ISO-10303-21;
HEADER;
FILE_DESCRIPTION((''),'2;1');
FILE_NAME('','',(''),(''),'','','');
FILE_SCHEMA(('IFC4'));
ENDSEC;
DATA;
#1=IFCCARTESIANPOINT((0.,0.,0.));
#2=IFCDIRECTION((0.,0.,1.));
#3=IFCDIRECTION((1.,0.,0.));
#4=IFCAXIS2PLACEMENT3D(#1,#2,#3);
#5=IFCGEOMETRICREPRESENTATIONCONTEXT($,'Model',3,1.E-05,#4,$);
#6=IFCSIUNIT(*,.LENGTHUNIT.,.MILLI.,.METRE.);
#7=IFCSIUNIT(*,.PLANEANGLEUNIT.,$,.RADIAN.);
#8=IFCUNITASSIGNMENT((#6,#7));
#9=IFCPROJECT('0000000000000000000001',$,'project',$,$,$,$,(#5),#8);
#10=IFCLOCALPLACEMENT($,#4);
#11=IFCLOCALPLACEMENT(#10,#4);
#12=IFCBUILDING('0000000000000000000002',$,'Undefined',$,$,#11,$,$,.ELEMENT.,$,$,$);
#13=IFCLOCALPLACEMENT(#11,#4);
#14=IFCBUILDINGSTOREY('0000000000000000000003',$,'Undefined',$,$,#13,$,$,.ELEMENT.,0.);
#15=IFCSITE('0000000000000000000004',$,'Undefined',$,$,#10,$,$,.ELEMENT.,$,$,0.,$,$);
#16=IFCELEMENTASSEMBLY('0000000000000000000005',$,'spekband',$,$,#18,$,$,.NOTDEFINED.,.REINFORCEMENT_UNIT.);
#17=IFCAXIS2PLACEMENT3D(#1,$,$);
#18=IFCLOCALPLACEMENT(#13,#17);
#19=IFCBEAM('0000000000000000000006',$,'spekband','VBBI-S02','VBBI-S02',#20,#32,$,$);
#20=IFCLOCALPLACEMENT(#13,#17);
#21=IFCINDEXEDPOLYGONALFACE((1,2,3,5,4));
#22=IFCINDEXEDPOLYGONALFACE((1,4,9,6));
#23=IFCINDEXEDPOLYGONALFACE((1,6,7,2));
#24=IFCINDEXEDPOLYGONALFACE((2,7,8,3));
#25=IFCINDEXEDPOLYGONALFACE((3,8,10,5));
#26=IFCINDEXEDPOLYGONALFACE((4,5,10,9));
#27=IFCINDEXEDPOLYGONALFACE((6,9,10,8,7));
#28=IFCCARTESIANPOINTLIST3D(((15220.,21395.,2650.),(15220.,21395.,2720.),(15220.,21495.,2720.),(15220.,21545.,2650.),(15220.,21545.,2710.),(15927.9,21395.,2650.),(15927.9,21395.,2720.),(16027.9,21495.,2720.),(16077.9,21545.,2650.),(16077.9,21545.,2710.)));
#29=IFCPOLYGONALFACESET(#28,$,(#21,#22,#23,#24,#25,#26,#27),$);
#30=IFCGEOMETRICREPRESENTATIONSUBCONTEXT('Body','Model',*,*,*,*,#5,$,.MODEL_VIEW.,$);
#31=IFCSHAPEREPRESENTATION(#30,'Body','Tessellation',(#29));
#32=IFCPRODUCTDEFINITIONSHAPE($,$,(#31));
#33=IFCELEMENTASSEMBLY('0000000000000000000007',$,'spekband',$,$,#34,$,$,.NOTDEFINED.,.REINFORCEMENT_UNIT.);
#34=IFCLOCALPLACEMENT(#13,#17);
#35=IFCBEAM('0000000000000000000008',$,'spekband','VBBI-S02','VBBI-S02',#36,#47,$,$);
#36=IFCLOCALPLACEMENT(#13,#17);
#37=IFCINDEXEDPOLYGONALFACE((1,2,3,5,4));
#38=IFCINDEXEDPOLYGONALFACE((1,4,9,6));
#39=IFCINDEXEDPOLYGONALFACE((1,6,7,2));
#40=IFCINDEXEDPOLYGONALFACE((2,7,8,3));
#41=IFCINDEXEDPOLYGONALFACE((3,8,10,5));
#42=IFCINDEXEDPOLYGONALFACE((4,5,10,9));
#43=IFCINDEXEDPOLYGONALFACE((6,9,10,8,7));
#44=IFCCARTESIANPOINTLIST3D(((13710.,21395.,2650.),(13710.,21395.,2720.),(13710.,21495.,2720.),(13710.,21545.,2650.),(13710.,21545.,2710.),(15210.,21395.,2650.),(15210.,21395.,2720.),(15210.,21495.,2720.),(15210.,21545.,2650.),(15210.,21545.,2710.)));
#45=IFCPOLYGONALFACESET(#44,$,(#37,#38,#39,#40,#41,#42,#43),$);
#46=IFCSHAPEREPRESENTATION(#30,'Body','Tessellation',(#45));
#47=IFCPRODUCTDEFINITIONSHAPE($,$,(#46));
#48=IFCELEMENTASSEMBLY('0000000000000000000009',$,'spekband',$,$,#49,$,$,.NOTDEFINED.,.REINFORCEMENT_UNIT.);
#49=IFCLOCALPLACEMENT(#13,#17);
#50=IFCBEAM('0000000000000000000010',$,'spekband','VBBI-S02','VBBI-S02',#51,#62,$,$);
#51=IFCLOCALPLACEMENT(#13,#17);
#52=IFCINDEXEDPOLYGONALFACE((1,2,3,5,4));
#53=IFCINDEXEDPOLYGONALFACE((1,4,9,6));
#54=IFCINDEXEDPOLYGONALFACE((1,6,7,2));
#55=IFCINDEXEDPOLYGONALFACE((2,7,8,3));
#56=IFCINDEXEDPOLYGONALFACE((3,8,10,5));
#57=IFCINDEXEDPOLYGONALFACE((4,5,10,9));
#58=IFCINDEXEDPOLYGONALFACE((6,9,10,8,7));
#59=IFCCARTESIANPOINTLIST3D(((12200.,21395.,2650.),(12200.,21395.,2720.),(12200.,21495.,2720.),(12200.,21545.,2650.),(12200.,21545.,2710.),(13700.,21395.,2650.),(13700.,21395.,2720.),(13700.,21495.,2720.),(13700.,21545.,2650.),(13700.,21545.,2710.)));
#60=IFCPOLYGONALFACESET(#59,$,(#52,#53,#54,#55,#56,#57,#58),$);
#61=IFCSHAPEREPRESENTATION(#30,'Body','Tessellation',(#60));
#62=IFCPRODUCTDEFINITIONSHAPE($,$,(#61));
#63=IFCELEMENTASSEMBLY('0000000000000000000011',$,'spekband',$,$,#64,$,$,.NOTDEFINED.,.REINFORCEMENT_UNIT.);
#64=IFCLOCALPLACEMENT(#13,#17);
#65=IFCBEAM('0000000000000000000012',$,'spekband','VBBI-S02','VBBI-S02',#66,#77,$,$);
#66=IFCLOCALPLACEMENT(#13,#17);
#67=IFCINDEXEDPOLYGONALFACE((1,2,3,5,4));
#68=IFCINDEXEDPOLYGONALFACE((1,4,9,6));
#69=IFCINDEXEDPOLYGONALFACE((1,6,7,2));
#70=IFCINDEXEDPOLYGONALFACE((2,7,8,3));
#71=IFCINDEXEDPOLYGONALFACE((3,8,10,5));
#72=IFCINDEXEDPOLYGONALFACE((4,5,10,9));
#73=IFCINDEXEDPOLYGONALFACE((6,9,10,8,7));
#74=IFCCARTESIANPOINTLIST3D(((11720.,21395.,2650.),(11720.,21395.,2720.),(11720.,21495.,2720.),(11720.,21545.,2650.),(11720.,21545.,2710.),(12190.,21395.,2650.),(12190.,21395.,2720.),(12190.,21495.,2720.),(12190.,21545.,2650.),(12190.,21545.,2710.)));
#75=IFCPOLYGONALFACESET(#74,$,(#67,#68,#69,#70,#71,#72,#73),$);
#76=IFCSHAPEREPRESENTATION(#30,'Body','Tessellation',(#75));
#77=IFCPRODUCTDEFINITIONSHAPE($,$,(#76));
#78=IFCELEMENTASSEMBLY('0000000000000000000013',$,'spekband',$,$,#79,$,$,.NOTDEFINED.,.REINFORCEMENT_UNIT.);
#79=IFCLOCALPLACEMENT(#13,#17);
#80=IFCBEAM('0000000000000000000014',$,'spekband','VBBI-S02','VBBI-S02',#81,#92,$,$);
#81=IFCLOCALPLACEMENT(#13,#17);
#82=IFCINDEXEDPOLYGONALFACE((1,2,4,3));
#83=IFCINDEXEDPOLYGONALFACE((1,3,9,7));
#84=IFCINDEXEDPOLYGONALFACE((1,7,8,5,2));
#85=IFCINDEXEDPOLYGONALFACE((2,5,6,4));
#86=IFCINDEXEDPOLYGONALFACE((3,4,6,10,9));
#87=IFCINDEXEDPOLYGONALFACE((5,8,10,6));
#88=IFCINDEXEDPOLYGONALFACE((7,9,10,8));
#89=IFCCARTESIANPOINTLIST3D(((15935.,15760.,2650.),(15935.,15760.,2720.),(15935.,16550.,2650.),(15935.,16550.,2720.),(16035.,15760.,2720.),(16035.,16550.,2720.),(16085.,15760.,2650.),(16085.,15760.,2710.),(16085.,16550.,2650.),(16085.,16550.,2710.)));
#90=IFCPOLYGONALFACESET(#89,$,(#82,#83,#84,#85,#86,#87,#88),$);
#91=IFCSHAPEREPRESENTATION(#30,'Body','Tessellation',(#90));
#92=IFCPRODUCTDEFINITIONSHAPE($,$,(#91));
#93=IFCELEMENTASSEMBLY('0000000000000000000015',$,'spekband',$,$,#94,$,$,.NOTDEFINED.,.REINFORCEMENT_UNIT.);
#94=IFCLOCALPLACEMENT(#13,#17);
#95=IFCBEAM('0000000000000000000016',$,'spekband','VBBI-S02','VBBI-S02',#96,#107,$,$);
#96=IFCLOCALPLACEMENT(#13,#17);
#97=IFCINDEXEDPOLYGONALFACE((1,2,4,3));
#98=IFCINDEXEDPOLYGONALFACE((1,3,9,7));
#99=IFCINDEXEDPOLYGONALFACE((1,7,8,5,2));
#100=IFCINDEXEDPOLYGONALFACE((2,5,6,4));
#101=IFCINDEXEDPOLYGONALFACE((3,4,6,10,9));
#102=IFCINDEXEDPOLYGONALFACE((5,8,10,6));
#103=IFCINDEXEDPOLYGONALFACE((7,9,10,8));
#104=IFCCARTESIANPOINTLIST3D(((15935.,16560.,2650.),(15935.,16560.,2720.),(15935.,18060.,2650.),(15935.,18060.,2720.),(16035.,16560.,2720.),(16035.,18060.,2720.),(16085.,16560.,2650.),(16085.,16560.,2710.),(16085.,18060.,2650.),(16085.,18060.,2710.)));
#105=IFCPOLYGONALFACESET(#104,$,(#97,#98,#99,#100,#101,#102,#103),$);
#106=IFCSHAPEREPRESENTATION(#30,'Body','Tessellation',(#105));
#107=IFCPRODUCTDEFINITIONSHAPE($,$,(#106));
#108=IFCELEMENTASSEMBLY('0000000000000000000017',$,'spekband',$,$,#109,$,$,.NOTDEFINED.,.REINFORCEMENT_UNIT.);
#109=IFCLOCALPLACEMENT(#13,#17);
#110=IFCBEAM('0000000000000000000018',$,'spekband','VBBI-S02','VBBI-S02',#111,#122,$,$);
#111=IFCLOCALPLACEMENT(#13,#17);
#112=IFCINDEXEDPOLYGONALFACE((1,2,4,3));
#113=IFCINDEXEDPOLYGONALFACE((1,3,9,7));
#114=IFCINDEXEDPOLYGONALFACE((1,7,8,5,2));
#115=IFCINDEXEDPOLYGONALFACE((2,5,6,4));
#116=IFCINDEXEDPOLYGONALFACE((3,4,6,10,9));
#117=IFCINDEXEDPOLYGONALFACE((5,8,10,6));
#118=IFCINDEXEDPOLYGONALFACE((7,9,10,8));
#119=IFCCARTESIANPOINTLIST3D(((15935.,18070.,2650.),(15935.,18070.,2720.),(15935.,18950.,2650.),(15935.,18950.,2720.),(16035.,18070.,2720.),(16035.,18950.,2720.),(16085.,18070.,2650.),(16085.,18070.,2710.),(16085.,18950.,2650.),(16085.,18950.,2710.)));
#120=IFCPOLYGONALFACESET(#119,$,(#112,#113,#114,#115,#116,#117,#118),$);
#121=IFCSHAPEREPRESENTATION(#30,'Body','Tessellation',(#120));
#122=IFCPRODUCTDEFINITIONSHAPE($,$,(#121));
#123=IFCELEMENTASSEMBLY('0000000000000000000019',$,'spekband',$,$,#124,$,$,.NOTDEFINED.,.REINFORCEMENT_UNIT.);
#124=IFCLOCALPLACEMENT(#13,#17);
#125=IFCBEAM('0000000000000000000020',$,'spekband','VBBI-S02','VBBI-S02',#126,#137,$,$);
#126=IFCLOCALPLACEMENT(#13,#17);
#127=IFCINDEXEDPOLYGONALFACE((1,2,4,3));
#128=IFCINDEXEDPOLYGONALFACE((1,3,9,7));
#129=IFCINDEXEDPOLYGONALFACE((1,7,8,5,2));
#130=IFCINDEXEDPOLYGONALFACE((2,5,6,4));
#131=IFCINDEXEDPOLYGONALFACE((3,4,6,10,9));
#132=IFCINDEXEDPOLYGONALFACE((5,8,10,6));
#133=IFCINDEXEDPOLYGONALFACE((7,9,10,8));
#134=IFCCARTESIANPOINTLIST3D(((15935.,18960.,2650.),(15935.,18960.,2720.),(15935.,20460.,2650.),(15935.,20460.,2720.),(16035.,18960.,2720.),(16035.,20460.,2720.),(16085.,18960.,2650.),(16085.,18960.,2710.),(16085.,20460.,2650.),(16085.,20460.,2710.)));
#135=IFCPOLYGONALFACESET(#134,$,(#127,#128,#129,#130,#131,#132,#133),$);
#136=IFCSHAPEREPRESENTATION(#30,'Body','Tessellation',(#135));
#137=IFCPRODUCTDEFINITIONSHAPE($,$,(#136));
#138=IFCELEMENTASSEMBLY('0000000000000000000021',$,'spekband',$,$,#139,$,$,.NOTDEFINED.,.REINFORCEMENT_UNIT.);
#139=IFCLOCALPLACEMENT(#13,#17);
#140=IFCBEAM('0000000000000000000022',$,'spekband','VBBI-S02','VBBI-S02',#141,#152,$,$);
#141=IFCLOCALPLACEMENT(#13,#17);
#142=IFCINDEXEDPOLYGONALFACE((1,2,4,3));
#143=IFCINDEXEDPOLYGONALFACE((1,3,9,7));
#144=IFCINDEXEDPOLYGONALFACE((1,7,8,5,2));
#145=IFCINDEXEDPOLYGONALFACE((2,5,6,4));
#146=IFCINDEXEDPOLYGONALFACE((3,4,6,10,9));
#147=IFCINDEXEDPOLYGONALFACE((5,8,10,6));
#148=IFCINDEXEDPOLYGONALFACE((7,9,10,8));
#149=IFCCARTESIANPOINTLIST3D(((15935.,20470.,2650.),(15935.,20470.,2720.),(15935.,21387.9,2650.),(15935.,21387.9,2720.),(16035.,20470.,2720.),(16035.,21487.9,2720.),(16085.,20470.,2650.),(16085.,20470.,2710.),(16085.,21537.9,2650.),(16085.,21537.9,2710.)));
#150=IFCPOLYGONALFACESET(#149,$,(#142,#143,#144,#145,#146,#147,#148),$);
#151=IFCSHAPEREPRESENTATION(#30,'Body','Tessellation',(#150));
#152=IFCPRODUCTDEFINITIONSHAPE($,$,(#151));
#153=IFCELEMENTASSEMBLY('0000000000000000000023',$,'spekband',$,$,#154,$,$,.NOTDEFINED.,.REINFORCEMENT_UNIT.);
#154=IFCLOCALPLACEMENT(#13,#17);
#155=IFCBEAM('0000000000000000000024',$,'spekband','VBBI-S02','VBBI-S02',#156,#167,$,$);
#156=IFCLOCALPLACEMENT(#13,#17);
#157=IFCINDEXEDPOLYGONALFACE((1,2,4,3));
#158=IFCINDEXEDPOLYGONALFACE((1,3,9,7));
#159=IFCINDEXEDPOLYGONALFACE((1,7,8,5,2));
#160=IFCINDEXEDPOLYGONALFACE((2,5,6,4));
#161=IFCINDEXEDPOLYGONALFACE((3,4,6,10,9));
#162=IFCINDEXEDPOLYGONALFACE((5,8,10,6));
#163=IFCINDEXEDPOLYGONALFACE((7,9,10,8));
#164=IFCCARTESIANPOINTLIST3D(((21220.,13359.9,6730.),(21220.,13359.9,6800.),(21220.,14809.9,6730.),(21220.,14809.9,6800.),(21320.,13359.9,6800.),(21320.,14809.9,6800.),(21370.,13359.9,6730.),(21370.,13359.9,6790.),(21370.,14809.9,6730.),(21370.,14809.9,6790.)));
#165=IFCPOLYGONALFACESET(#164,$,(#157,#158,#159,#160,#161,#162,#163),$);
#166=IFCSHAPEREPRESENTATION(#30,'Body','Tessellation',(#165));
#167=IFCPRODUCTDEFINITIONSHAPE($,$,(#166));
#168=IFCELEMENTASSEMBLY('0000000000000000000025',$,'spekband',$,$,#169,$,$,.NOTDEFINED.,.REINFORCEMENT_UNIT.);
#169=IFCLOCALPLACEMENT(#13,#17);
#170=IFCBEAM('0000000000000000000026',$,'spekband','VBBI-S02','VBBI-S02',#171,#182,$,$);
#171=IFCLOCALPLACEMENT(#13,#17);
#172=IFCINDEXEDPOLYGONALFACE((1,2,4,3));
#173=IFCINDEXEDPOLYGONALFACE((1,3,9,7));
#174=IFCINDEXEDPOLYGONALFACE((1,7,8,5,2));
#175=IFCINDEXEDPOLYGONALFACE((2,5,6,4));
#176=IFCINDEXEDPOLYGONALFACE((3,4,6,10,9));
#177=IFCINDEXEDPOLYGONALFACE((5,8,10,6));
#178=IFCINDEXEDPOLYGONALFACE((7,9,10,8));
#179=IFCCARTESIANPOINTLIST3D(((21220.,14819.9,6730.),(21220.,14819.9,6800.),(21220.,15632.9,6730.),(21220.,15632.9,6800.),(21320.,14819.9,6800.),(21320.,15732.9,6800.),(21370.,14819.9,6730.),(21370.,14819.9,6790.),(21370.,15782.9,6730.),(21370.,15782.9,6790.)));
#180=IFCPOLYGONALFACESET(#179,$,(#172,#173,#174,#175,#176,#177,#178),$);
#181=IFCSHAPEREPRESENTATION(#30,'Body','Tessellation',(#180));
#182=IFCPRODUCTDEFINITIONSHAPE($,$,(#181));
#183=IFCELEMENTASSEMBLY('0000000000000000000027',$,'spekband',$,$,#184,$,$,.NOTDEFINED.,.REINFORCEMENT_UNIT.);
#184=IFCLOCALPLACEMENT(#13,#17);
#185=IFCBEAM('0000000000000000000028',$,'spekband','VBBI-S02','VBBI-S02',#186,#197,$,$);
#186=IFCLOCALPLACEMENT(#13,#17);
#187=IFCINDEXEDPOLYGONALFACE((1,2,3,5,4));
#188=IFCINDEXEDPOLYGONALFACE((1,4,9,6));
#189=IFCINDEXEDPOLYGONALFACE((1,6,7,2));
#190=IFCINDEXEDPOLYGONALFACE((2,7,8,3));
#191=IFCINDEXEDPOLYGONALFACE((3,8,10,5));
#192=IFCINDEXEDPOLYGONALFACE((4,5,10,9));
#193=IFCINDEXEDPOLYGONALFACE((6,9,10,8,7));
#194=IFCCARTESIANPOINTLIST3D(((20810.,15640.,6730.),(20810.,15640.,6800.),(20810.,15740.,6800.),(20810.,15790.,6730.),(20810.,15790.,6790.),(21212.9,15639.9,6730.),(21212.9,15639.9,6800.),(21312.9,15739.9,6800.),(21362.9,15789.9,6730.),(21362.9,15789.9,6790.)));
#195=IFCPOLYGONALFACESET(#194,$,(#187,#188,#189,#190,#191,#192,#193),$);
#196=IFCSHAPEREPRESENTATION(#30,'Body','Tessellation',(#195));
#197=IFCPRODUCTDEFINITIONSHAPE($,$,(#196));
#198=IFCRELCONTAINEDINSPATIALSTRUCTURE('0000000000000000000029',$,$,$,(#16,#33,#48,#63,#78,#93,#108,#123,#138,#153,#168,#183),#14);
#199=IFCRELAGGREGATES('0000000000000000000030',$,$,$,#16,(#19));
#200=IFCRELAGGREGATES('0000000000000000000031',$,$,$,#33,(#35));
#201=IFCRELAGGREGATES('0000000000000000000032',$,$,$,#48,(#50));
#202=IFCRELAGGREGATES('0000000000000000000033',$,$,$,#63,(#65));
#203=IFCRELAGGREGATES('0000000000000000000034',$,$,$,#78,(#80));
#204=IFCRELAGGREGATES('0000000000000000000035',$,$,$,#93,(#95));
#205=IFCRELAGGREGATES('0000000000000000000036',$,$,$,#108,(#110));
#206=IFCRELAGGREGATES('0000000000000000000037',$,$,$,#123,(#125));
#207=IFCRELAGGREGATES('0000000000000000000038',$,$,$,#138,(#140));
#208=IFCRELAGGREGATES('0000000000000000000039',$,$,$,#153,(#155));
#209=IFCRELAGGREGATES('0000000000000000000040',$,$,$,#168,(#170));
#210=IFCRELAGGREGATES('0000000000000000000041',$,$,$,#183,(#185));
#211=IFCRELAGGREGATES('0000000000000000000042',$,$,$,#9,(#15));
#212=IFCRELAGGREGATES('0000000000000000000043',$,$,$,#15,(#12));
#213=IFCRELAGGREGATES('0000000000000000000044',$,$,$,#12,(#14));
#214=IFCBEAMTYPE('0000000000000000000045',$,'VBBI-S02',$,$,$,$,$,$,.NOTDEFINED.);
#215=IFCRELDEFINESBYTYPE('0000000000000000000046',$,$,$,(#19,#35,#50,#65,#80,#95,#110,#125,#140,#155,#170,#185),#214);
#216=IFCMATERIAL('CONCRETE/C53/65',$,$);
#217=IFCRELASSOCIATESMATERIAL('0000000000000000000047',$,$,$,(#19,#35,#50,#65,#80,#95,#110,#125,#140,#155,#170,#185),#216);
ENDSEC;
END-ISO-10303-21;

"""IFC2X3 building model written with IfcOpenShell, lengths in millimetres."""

from ifc_helpers import new_model, si_unit, frame, origin_with_axes, place, context, subcontext, project, spatial, polyline, outline, extrude, clip, halfspace, material, type_object, element, aggregate, save


model = new_model("IFC2X3")

# Units and contexts
model_context = context("Model", 3, precision=1e-05, world=origin_with_axes())
body_context = subcontext(model_context, "Body", "Model", "MODEL_VIEW")
ifc_project = project(units=[si_unit("LENGTHUNIT", "METRE", prefix="MILLI"), si_unit("PLANEANGLEUNIT", "RADIAN")], contexts=[model_context])

# Site, building, storey
site_placement = place(None, origin_with_axes())
site = spatial("IfcSite", under=ifc_project, at=site_placement, Name="Undefined", CompositionType="ELEMENT", RefElevation=0.0)
building_placement = place(site_placement, origin_with_axes())
building = spatial("IfcBuilding", under=site, at=building_placement, Name="Undefined", CompositionType="ELEMENT")
storey_placement = place(building_placement, origin_with_axes())
storey = spatial("IfcBuildingStorey", under=building, at=storey_placement, Name="Undefined", CompositionType="ELEMENT", Elevation=0.0)

# Element assemblies, beams
assembly_1_placement = place(storey_placement, origin_with_axes())
assembly_1 = element("IfcElementAssembly", 1, at=assembly_1_placement, inside=storey, Name="spekband", AssemblyPlace="NOTDEFINED", PredefinedType="REINFORCEMENT_UNIT")
ifc_material = material(Name="CONCRETE/C53/65")
beam_type_1 = type_object("IfcBeamType", Name="VBBI-S02", PredefinedType="NOTDEFINED")
beam_1_placement = place(assembly_1_placement, frame((16085.0, 21470.0, 2685.0), z_axis=(0.0, 1.0, 0.0), x_axis=(-1.0, 0.0, 0.0)))
beam_1 = element("IfcBeam", 2, at=beam_1_placement, type_object=beam_type_1, material=ifc_material, Name="spekband", Description="VBBI-S02", ObjectType="VBBI-S02", context=body_context, shape_type="Clipping", body=[
    clip(extrude(outline(polyline([(35.0, -75.0), (-35.0, -75.0), (-35.0, 25.0), (-25.0, 75.0), (35.0, 75.0), (35.0, -75.0)])), frame((865.0, 0.0, 0.0), z_axis=(-1.0, 0.0, 0.0), x_axis=(0.0, -1.0, 0.0)), (0.0, 0.0, 1.0), 858.7), halfspace(frame((3.5, 0.0, 78.5), z_axis=(0.707107, 0.0, 0.707106), x_axis=(0.0, 1.0, 0.0)), True)),
])
aggregate(assembly_1, [beam_1])
assembly_2_placement = place(storey_placement, origin_with_axes())
assembly_2 = element("IfcElementAssembly", 3, at=assembly_2_placement, inside=storey, Name="spekband", AssemblyPlace="NOTDEFINED", PredefinedType="REINFORCEMENT_UNIT")
beam_2_placement = place(assembly_2_placement, frame((15210.0, 21470.0, 2685.0), z_axis=(0.0, 1.0, 0.0), x_axis=(-1.0, 0.0, 0.0)))
beam_2 = element("IfcBeam", 4, at=beam_2_placement, type_object=beam_type_1, material=ifc_material, Name="spekband", Description="VBBI-S02", ObjectType="VBBI-S02", context=body_context, shape_type="SweptSolid", body=[
    extrude(outline(polyline([(35.0, -75.0), (-35.0, -75.0), (-35.0, 25.0), (-25.0, 75.0), (35.0, 75.0), (35.0, -75.0)])), frame((1500.0, 0.0, 0.0), z_axis=(-1.0, 0.0, 0.0), x_axis=(0.0, -1.0, 0.0)), (0.0, 0.0, 1.0), 1500.0),
])
aggregate(assembly_2, [beam_2])
assembly_3_placement = place(storey_placement, origin_with_axes())
assembly_3 = element("IfcElementAssembly", 5, at=assembly_3_placement, inside=storey, Name="spekband", AssemblyPlace="NOTDEFINED", PredefinedType="REINFORCEMENT_UNIT")
beam_3_placement = place(assembly_3_placement, frame((13700.0, 21470.0, 2685.0), z_axis=(0.0, 1.0, 0.0), x_axis=(-1.0, 0.0, 0.0)))
beam_3 = element("IfcBeam", 6, at=beam_3_placement, type_object=beam_type_1, material=ifc_material, Name="spekband", Description="VBBI-S02", ObjectType="VBBI-S02", context=body_context, shape_type="SweptSolid", body=[
    extrude(outline(polyline([(35.0, -75.0), (-35.0, -75.0), (-35.0, 25.0), (-25.0, 75.0), (35.0, 75.0), (35.0, -75.0)])), frame((1500.0, 0.0, 0.0), z_axis=(-1.0, 0.0, 0.0), x_axis=(0.0, -1.0, 0.0)), (0.0, 0.0, 1.0), 1500.0),
])
aggregate(assembly_3, [beam_3])
assembly_4_placement = place(storey_placement, origin_with_axes())
assembly_4 = element("IfcElementAssembly", 7, at=assembly_4_placement, inside=storey, Name="spekband", AssemblyPlace="NOTDEFINED", PredefinedType="REINFORCEMENT_UNIT")
beam_4_placement = place(assembly_4_placement, frame((12190.0, 21470.0, 2685.0), z_axis=(0.0, 1.0, 0.0), x_axis=(-1.0, 0.0, 0.0)))
beam_4 = element("IfcBeam", 8, at=beam_4_placement, type_object=beam_type_1, material=ifc_material, Name="spekband", Description="VBBI-S02", ObjectType="VBBI-S02", context=body_context, shape_type="SweptSolid", body=[
    extrude(outline(polyline([(35.0, -75.0), (-35.0, -75.0), (-35.0, 25.0), (-25.0, 75.0), (35.0, 75.0), (35.0, -75.0)])), frame((470.0, 0.0, 0.0), z_axis=(-1.0, 0.0, 0.0), x_axis=(0.0, -1.0, 0.0)), (0.0, 0.0, 1.0), 470.0),
])
aggregate(assembly_4, [beam_4])
assembly_5_placement = place(storey_placement, origin_with_axes())
assembly_5 = element("IfcElementAssembly", 9, at=assembly_5_placement, inside=storey, Name="spekband", AssemblyPlace="NOTDEFINED", PredefinedType="REINFORCEMENT_UNIT")
beam_5_placement = place(assembly_5_placement, frame((16010.0, 15760.0, 2685.0), z_axis=(1.0, 0.000002, 0.0), x_axis=(-0.000002, 1.0, 0.0)))
beam_5 = element("IfcBeam", 10, at=beam_5_placement, type_object=beam_type_1, material=ifc_material, Name="spekband", Description="VBBI-S02", ObjectType="VBBI-S02", context=body_context, shape_type="SweptSolid", body=[
    extrude(outline(polyline([(35.0, -75.0), (-35.0, -75.0), (-35.0, 25.0), (-25.0, 75.0), (35.0, 75.0), (35.0, -75.0)])), frame((790.0, 0.0, 0.0), z_axis=(-1.0, 0.0, 0.0), x_axis=(0.0, -1.0, 0.0)), (0.0, 0.0, 1.0), 790.0),
])
aggregate(assembly_5, [beam_5])
assembly_6_placement = place(storey_placement, origin_with_axes())
assembly_6 = element("IfcElementAssembly", 11, at=assembly_6_placement, inside=storey, Name="spekband", AssemblyPlace="NOTDEFINED", PredefinedType="REINFORCEMENT_UNIT")
beam_6_placement = place(assembly_6_placement, frame((16010.0, 16560.0, 2685.0), z_axis=(1.0, 0.000001, 0.0), x_axis=(-0.000001, 1.0, 0.0)))
beam_6 = element("IfcBeam", 12, at=beam_6_placement, type_object=beam_type_1, material=ifc_material, Name="spekband", Description="VBBI-S02", ObjectType="VBBI-S02", context=body_context, shape_type="SweptSolid", body=[
    extrude(outline(polyline([(35.0, -75.0), (-35.0, -75.0), (-35.0, 25.0), (-25.0, 75.0), (35.0, 75.0), (35.0, -75.0)])), frame((1500.0, 0.0, 0.0), z_axis=(-1.0, 0.0, 0.0), x_axis=(0.0, -1.0, 0.0)), (0.0, 0.0, 1.0), 1500.0),
])
aggregate(assembly_6, [beam_6])
assembly_7_placement = place(storey_placement, origin_with_axes())
assembly_7 = element("IfcElementAssembly", 13, at=assembly_7_placement, inside=storey, Name="spekband", AssemblyPlace="NOTDEFINED", PredefinedType="REINFORCEMENT_UNIT")
beam_7_placement = place(assembly_7_placement, frame((16010.0, 18070.0, 2685.0), z_axis=(1.0, 0.000002, 0.0), x_axis=(-0.000002, 1.0, 0.0)))
beam_7 = element("IfcBeam", 14, at=beam_7_placement, type_object=beam_type_1, material=ifc_material, Name="spekband", Description="VBBI-S02", ObjectType="VBBI-S02", context=body_context, shape_type="SweptSolid", body=[
    extrude(outline(polyline([(35.0, -75.0), (-35.0, -75.0), (-35.0, 25.0), (-25.0, 75.0), (35.0, 75.0), (35.0, -75.0)])), frame((880.0, 0.0, 0.0), z_axis=(-1.0, 0.0, 0.0), x_axis=(0.0, -1.0, 0.0)), (0.0, 0.0, 1.0), 880.0),
])
aggregate(assembly_7, [beam_7])
assembly_8_placement = place(storey_placement, origin_with_axes())
assembly_8 = element("IfcElementAssembly", 15, at=assembly_8_placement, inside=storey, Name="spekband", AssemblyPlace="NOTDEFINED", PredefinedType="REINFORCEMENT_UNIT")
beam_8_placement = place(assembly_8_placement, frame((16010.0, 18960.0, 2685.0), z_axis=(1.0, 0.000001, 0.0), x_axis=(-0.000001, 1.0, 0.0)))
beam_8 = element("IfcBeam", 16, at=beam_8_placement, type_object=beam_type_1, material=ifc_material, Name="spekband", Description="VBBI-S02", ObjectType="VBBI-S02", context=body_context, shape_type="SweptSolid", body=[
    extrude(outline(polyline([(35.0, -75.0), (-35.0, -75.0), (-35.0, 25.0), (-25.0, 75.0), (35.0, 75.0), (35.0, -75.0)])), frame((1500.0, 0.0, 0.0), z_axis=(-1.0, 0.0, 0.0), x_axis=(0.0, -1.0, 0.0)), (0.0, 0.0, 1.0), 1500.0),
])
aggregate(assembly_8, [beam_8])
assembly_9_placement = place(storey_placement, origin_with_axes())
assembly_9 = element("IfcElementAssembly", 17, at=assembly_9_placement, inside=storey, Name="spekband", AssemblyPlace="NOTDEFINED", PredefinedType="REINFORCEMENT_UNIT")
beam_9_placement = place(assembly_9_placement, frame((16010.0, 20470.0, 2685.0), z_axis=(1.0, 0.000002, 0.0), x_axis=(-0.000002, 1.0, 0.0)))
beam_9 = element("IfcBeam", 18, at=beam_9_placement, type_object=beam_type_1, material=ifc_material, Name="spekband", Description="VBBI-S02", ObjectType="VBBI-S02", context=body_context, shape_type="Clipping", body=[
    clip(extrude(outline(polyline([(35.0, -75.0), (-35.0, -75.0), (-35.0, 25.0), (-25.0, 75.0), (35.0, 75.0), (35.0, -75.0)])), frame((1068.7, 0.0, 0.0), z_axis=(-1.0, 0.0, 0.0), x_axis=(0.0, -1.0, 0.0)), (0.0, 0.0, 1.0), 1068.7), halfspace(frame((1071.5, 0.0, 78.5), z_axis=(0.707107, 0.0, -0.707107), x_axis=(0.0, 1.0, 0.0)), False)),
])
aggregate(assembly_9, [beam_9])
assembly_10_placement = place(storey_placement, origin_with_axes())
assembly_10 = element("IfcElementAssembly", 19, at=assembly_10_placement, inside=storey, Name="spekband", AssemblyPlace="NOTDEFINED", PredefinedType="REINFORCEMENT_UNIT")
beam_10_placement = place(assembly_10_placement, frame((21295.0, 13359.9, 6765.0), z_axis=(1.0, 0.0, 0.0), x_axis=(0.0, 1.0, 0.0)))
beam_10 = element("IfcBeam", 20, at=beam_10_placement, type_object=beam_type_1, material=ifc_material, Name="spekband", Description="VBBI-S02", ObjectType="VBBI-S02", context=body_context, shape_type="SweptSolid", body=[
    extrude(outline(polyline([(35.0, -75.0), (-35.0, -75.0), (-35.0, 25.0), (-25.0, 75.0), (35.0, 75.0), (35.0, -75.0)])), frame((1450.0, 0.0, 0.0), z_axis=(-1.0, 0.0, 0.0), x_axis=(0.0, -1.0, 0.0)), (0.0, 0.0, 1.0), 1450.0),
])
aggregate(assembly_10, [beam_10])
assembly_11_placement = place(storey_placement, origin_with_axes())
assembly_11 = element("IfcElementAssembly", 21, at=assembly_11_placement, inside=storey, Name="spekband", AssemblyPlace="NOTDEFINED", PredefinedType="REINFORCEMENT_UNIT")
beam_11_placement = place(assembly_11_placement, frame((21295.0, 14819.9, 6765.0), z_axis=(1.0, 0.000002, 0.0), x_axis=(-0.000002, 1.0, 0.0)))
beam_11 = element("IfcBeam", 22, at=beam_11_placement, type_object=beam_type_1, material=ifc_material, Name="spekband", Description="VBBI-S02", ObjectType="VBBI-S02", context=body_context, shape_type="Clipping", body=[
    clip(extrude(outline(polyline([(35.0, -75.0), (-35.0, -75.0), (-35.0, 25.0), (-25.0, 75.0), (35.0, 75.0), (35.0, -75.0)])), frame((963.7, 0.0, 0.0), z_axis=(-1.0, 0.0, 0.0), x_axis=(0.0, -1.0, 0.0)), (0.0, 0.0, 1.0), 963.7), halfspace(frame((966.5, 0.0, 78.5), z_axis=(0.707156, 0.0, -0.707057), x_axis=(0.0, 1.0, 0.0)), False)),
])
aggregate(assembly_11, [beam_11])
assembly_12_placement = place(storey_placement, origin_with_axes())
assembly_12 = element("IfcElementAssembly", 23, at=assembly_12_placement, inside=storey, Name="spekband", AssemblyPlace="NOTDEFINED", PredefinedType="REINFORCEMENT_UNIT")
beam_12_placement = place(assembly_12_placement, frame((21370.0, 15714.9, 6765.0), z_axis=(0.000138, 1.0, 0.0), x_axis=(-1.0, 0.000138, 0.0)))
beam_12 = element("IfcBeam", 24, at=beam_12_placement, type_object=beam_type_1, material=ifc_material, Name="spekband", Description="VBBI-S02", ObjectType="VBBI-S02", context=body_context, shape_type="Clipping", body=[
    clip(extrude(outline(polyline([(35.0, -75.0), (-35.0, -75.0), (-35.0, 25.0), (-25.0, 75.0), (35.0, 75.0), (35.0, -75.0)])), frame((560.0, 0.0, 0.0), z_axis=(-1.0, 0.0, 0.0), x_axis=(0.0, -1.0, 0.0)), (0.0, 0.0, 1.0), 553.7), halfspace(frame((3.5, 0.0, 78.5), z_axis=(0.707156, 0.0, 0.707057), x_axis=(0.0, 1.0, 0.0)), True)),
])
aggregate(assembly_12, [beam_12])

save(model, "model.ifc")
